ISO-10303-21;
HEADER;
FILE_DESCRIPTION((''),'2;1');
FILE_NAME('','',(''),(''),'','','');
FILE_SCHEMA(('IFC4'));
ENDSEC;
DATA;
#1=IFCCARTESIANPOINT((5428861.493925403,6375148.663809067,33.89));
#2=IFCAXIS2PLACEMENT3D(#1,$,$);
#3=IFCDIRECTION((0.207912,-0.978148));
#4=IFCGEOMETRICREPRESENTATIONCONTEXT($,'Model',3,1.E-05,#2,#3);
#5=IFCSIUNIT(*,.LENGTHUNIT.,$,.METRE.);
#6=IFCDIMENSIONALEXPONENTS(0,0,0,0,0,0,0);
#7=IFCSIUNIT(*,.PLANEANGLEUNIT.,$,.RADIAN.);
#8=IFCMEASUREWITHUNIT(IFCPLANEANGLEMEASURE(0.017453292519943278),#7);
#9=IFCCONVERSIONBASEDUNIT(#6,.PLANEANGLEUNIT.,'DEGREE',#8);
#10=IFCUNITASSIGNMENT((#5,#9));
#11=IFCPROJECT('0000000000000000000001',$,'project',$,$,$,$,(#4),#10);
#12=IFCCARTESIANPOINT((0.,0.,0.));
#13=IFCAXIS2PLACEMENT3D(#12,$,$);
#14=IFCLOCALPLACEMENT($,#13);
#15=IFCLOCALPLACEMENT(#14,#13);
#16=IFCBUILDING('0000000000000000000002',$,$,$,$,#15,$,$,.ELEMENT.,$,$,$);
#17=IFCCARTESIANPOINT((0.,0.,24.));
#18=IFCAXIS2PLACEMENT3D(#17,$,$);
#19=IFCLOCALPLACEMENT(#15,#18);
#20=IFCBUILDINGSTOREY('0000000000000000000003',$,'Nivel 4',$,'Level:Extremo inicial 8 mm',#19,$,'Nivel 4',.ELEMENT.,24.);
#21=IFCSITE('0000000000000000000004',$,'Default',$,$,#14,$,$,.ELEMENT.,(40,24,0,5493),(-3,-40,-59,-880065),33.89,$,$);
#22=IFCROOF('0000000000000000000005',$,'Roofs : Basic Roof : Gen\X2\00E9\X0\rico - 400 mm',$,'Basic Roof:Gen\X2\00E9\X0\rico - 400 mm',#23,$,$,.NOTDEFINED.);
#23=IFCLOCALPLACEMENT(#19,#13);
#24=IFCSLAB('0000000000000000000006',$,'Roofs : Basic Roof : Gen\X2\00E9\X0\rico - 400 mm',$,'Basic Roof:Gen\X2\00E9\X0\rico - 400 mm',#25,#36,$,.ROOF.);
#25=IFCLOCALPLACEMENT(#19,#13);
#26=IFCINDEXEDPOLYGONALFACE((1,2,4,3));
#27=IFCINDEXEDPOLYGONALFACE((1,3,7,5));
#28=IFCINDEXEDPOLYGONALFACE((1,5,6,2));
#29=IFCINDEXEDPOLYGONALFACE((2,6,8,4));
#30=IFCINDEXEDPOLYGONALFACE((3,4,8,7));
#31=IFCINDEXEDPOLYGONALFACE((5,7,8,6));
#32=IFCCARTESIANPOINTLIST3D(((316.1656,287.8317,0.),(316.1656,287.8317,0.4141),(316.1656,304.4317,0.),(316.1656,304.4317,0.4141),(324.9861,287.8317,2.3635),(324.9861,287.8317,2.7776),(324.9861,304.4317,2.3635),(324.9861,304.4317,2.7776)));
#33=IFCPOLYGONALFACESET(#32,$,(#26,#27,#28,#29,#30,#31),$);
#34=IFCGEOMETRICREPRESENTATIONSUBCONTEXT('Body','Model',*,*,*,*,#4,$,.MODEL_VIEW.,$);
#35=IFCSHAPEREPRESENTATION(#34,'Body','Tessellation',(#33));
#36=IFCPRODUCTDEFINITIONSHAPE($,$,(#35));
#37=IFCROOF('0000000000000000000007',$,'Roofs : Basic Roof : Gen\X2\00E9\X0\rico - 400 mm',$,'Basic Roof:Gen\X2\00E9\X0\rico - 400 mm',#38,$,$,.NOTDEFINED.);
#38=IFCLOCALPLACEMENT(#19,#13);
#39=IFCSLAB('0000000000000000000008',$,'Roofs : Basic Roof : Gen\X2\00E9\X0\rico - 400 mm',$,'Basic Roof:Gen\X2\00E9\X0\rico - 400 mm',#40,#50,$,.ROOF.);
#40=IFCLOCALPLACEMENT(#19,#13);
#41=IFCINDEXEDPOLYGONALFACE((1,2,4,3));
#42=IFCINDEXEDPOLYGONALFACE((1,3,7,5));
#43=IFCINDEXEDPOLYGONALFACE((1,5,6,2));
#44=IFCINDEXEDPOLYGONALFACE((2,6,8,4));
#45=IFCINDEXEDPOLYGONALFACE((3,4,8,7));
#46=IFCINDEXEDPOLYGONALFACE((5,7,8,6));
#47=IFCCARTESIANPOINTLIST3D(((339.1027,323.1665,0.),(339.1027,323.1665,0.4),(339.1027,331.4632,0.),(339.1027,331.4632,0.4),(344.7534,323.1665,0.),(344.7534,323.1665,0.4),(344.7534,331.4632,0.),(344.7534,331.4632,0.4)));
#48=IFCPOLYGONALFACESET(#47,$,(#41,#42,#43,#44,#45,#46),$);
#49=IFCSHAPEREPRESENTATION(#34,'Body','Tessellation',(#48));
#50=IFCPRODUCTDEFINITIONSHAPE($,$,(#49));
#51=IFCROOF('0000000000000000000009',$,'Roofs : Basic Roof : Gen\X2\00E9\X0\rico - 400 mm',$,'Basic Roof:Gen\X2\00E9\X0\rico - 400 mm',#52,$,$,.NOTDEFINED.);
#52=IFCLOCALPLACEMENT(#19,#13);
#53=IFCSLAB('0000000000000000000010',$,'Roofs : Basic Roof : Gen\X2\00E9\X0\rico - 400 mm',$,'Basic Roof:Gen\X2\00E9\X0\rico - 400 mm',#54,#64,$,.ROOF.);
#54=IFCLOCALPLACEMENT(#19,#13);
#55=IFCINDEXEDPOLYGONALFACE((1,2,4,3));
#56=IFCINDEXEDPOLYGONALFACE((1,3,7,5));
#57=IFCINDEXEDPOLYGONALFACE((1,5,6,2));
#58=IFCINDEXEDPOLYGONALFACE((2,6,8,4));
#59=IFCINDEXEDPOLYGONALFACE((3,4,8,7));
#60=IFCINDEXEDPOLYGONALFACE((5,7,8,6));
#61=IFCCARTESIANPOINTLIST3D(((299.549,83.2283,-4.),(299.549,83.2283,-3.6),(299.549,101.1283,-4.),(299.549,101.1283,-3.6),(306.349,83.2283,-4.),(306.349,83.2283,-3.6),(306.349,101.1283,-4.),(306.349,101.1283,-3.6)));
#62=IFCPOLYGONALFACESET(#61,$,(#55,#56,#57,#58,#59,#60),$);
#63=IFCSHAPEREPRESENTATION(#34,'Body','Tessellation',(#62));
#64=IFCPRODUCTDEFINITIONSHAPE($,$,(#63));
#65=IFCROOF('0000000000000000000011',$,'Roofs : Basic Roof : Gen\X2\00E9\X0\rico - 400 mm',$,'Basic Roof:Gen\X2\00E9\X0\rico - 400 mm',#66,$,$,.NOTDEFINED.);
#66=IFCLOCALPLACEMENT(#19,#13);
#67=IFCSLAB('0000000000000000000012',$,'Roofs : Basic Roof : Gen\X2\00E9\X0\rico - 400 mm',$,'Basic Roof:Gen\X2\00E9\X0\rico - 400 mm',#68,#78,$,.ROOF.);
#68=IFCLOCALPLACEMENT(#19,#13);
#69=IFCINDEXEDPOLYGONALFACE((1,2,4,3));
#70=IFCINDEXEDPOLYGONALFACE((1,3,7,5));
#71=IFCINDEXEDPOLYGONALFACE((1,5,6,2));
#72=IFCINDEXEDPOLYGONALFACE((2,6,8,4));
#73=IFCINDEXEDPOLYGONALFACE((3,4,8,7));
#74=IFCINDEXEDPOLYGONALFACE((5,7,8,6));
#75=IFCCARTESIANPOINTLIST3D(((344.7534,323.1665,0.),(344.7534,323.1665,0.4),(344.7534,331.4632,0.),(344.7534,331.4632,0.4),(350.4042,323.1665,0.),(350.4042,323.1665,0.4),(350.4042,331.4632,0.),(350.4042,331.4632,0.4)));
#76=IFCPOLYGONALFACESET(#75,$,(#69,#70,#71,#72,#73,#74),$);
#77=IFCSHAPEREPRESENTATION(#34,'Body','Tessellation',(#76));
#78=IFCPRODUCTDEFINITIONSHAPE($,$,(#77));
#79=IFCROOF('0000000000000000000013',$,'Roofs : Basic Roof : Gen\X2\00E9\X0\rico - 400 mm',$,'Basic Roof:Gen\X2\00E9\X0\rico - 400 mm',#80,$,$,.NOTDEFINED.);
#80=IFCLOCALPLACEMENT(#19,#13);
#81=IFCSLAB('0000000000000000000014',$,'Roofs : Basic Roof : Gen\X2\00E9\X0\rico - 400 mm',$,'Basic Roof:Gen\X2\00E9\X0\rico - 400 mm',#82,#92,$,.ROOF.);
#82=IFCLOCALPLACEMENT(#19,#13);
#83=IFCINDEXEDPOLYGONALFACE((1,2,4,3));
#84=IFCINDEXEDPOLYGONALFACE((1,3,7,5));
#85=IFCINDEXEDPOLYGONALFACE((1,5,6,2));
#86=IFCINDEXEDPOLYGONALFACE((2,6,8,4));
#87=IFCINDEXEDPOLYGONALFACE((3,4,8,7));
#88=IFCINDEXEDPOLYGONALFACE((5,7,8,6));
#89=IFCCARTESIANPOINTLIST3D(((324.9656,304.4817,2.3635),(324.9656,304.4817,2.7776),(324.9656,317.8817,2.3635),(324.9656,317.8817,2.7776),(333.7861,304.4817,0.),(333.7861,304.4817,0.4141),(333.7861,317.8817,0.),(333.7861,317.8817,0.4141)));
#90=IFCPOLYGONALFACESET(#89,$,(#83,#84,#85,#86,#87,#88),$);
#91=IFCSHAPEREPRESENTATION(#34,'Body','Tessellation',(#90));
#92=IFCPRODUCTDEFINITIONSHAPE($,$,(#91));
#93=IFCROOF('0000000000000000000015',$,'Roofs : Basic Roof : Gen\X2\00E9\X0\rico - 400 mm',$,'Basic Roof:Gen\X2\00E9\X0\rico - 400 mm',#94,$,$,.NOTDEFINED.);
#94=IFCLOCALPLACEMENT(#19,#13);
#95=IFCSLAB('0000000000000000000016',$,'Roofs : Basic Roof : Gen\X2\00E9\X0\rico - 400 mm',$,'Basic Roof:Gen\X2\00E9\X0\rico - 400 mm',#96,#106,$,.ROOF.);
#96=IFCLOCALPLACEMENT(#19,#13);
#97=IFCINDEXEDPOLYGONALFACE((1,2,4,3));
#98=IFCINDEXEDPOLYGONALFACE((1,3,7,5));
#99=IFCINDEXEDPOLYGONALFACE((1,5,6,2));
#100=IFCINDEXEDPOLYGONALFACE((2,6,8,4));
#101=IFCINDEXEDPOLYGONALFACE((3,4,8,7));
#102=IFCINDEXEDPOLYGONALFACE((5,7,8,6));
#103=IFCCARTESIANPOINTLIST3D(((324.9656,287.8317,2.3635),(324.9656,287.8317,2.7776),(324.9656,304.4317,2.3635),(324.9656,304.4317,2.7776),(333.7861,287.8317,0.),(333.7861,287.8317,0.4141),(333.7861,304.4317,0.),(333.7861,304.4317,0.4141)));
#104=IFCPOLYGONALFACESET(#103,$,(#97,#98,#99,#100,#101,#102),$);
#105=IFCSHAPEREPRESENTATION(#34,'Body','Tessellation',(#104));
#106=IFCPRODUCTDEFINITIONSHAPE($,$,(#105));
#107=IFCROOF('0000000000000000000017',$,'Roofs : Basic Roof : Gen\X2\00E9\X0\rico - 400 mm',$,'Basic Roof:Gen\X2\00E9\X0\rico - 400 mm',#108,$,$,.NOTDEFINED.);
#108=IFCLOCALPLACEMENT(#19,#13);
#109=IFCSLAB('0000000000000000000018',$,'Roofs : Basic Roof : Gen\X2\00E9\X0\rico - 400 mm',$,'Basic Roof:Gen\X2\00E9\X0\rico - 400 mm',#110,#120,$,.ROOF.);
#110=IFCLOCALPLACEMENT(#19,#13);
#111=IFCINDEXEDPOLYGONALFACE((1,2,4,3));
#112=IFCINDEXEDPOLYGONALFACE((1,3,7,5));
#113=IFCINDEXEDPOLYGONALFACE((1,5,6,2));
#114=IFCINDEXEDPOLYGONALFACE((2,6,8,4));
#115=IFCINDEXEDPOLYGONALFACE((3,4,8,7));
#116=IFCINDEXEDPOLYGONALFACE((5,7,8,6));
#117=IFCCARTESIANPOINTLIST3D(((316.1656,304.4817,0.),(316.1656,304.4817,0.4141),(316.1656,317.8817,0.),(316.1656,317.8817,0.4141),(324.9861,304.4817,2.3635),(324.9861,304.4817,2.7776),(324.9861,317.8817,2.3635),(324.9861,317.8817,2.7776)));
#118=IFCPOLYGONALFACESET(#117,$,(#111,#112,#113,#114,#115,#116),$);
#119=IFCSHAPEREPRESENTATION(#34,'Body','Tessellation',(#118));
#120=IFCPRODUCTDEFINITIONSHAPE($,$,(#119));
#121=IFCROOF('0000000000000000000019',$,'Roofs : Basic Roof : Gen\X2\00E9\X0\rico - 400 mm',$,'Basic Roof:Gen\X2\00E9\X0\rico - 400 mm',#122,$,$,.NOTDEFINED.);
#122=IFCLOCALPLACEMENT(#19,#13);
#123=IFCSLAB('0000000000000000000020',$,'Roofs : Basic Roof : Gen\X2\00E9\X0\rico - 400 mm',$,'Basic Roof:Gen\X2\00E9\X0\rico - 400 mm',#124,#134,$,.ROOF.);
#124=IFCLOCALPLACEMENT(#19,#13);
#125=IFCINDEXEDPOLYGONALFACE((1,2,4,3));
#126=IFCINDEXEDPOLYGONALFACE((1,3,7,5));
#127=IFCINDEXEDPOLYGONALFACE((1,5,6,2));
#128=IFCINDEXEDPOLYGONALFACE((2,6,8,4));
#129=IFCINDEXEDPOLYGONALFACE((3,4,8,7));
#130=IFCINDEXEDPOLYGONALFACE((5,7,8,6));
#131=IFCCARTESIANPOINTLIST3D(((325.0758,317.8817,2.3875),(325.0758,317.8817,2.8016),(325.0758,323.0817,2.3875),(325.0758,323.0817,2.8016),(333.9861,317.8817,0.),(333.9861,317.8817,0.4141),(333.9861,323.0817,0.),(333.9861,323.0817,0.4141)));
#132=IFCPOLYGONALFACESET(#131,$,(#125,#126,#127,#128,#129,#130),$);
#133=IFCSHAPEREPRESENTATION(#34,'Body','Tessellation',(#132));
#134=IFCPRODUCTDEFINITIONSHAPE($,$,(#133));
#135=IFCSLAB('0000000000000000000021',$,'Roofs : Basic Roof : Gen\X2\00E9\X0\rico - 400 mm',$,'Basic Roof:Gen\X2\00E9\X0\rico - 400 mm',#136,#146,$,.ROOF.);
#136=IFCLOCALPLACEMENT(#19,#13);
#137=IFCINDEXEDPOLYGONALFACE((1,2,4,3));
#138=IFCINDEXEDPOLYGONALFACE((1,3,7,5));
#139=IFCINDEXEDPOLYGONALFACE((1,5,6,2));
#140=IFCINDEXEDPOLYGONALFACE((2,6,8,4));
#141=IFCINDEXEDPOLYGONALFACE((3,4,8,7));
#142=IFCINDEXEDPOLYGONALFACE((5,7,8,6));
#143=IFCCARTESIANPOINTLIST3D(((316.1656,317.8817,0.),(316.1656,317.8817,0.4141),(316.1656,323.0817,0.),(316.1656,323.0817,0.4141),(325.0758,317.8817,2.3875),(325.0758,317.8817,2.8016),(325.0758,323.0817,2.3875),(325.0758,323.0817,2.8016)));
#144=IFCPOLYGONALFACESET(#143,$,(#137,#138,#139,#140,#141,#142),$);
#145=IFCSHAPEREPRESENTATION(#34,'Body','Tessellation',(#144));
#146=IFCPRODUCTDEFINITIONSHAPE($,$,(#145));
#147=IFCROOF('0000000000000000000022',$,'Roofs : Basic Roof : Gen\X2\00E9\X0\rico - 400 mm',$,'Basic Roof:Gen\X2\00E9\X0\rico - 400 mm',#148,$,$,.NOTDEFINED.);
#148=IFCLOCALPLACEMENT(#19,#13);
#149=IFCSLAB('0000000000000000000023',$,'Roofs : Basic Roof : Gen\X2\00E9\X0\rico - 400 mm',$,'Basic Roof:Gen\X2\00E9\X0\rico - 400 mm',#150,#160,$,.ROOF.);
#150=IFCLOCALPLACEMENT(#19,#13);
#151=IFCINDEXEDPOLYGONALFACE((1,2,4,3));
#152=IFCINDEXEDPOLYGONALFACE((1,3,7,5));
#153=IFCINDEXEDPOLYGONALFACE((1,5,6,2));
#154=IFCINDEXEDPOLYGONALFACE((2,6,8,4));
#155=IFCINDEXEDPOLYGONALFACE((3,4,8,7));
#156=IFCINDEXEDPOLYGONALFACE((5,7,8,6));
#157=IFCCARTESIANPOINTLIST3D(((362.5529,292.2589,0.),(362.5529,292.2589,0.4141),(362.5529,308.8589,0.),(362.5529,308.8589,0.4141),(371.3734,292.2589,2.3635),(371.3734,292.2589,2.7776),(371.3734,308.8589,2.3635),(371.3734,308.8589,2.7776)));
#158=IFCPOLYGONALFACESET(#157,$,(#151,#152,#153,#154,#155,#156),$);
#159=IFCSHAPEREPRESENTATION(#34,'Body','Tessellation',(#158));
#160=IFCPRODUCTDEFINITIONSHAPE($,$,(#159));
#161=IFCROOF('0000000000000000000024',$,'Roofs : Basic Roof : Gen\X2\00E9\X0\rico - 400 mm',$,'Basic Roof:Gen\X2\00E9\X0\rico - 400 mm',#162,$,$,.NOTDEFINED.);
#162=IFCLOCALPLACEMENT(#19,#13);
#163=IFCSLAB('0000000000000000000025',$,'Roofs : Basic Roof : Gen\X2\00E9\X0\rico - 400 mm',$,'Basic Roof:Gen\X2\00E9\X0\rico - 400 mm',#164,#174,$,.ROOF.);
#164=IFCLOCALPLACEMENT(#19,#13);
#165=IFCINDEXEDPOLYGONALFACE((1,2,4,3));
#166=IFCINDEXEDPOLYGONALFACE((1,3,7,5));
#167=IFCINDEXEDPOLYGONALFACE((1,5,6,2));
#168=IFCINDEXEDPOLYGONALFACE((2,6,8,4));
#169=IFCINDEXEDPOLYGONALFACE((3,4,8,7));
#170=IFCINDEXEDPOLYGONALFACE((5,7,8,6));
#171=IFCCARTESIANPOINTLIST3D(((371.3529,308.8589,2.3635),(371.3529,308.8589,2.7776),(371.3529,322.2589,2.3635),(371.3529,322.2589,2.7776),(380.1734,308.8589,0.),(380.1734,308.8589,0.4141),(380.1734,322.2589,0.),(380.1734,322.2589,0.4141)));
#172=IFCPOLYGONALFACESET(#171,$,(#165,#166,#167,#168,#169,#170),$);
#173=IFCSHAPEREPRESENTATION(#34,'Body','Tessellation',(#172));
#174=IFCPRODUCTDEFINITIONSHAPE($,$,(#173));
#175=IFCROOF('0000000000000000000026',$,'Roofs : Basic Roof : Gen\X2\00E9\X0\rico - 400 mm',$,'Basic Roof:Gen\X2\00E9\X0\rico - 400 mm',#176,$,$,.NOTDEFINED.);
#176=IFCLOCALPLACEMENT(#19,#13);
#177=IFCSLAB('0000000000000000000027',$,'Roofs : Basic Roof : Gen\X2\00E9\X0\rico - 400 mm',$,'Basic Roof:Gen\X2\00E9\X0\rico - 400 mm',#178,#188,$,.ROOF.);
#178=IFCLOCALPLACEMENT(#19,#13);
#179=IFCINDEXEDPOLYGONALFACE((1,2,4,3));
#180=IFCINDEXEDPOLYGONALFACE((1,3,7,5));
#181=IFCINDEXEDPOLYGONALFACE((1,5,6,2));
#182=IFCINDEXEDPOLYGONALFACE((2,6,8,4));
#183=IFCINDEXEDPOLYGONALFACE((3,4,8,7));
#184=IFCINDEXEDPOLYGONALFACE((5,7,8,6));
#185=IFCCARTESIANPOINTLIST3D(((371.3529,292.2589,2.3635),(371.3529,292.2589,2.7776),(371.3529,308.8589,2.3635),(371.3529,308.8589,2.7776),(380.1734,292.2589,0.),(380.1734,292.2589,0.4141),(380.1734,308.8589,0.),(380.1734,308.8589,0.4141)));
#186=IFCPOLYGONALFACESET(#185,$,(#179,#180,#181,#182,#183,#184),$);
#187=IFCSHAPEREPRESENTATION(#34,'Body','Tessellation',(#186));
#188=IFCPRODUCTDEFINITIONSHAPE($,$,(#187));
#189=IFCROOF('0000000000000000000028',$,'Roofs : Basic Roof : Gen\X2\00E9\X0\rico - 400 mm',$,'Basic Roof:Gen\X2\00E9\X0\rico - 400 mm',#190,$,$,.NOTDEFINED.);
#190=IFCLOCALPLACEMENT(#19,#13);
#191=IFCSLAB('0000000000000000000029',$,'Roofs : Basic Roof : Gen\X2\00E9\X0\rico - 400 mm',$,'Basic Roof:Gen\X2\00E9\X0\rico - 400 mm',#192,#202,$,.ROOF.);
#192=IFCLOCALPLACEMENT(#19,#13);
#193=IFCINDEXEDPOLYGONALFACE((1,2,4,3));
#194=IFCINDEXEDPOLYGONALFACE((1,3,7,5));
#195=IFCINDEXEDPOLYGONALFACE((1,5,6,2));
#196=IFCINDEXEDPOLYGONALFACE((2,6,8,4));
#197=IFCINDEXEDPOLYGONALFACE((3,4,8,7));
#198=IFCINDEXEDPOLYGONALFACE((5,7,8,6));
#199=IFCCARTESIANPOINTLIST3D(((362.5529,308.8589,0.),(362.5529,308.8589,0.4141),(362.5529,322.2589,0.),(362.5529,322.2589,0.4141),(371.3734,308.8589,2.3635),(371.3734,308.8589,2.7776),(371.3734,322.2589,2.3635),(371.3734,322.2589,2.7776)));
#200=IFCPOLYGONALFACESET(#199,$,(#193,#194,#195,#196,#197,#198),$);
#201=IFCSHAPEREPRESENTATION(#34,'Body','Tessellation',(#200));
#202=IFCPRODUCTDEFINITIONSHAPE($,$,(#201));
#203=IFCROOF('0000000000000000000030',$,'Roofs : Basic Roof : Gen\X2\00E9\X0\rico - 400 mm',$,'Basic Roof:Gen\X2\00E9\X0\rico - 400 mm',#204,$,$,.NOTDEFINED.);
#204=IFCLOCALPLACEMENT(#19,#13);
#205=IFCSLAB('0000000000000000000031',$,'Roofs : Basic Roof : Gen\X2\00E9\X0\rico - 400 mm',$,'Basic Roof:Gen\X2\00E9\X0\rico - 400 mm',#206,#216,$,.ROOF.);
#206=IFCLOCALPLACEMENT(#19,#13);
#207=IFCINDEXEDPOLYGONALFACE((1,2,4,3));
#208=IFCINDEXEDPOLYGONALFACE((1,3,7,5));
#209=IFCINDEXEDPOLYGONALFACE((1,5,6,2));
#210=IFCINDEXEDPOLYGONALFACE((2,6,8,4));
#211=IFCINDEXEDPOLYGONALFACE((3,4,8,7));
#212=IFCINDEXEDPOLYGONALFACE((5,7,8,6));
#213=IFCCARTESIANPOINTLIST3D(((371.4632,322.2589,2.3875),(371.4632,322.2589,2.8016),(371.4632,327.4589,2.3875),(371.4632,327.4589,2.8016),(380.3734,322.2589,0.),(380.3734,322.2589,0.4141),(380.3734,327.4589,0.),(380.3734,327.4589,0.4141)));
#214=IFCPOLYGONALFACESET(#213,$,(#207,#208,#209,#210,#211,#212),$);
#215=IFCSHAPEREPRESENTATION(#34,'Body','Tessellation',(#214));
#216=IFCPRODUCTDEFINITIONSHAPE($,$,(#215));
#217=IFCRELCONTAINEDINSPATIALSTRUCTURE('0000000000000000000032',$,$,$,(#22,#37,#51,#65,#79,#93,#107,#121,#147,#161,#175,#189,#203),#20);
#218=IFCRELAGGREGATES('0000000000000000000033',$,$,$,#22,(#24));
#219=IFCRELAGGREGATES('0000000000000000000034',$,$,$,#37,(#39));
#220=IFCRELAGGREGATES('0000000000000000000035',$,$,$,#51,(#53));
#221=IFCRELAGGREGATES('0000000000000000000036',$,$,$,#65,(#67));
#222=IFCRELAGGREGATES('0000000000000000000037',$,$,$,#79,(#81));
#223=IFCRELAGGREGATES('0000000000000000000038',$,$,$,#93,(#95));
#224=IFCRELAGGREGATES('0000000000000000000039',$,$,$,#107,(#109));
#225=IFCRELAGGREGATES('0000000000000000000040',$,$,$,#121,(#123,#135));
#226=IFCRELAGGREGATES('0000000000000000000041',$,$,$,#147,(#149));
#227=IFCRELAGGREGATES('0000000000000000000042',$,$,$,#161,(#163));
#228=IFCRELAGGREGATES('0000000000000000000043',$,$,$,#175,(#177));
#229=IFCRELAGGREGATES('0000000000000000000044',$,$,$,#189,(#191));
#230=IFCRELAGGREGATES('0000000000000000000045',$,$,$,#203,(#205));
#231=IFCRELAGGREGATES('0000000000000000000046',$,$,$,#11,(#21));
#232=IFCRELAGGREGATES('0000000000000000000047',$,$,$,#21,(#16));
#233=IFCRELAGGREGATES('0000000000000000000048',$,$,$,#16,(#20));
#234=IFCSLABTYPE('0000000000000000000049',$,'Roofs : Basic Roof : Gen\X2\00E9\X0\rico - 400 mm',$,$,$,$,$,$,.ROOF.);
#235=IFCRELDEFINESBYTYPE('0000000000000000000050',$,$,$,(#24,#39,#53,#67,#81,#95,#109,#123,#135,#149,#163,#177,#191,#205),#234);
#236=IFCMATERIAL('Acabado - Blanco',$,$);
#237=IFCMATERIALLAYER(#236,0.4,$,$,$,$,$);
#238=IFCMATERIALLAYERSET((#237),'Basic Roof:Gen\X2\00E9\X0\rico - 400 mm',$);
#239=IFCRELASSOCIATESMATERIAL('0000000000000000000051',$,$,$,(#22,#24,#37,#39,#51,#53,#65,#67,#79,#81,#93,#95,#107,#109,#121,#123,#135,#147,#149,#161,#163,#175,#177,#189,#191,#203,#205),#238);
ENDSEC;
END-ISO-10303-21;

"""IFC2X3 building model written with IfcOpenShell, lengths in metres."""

from ifc_helpers import new_model, entity, si_unit, converted_unit, direction, frame, frame_2d, origin, place, context, subcontext, project, spatial, rectangle, extrude, material, layer, layer_set, type_object, element, aggregate, save


model = new_model("IFC2X3")

# Units and contexts
model_context = context("Model", 3, precision=1e-05, world=frame((5428861.493925403, 6375148.663809067, 33.89)), true_north=direction((0.207912, -0.978148)))
body_context = subcontext(model_context, "Body", "Model", "MODEL_VIEW")
ifc_project = project(units=[si_unit("LENGTHUNIT", "METRE"), converted_unit("PLANEANGLEUNIT", "DEGREE", entity("IfcPlaneAngleMeasure", 0.017453292519943278), si_unit("PLANEANGLEUNIT", "RADIAN"), dimensions=[0, 0, 0, 0, 0, 0, 0])], contexts=[model_context])

# Site, building, storey
site_placement = place(None, origin())
site = spatial("IfcSite", under=ifc_project, at=site_placement, Name="Default", CompositionType="ELEMENT", RefLatitude=(40, 24, 0, 5493), RefLongitude=(-3, -40, -59, -880065), RefElevation=33.89)
building_placement = place(site_placement, origin())
building = spatial("IfcBuilding", under=site, at=building_placement, CompositionType="ELEMENT")
storey_placement = place(building_placement, frame((0.0, 0.0, 24.0)))
storey = spatial("IfcBuildingStorey", under=building, at=storey_placement, Name="Nivel 4", ObjectType="Level:Extremo inicial 8 mm", LongName="Nivel 4", CompositionType="ELEMENT", Elevation=24.0)

# Roofs, slabs
ifc_material = material(Name="Acabado - Blanco")
ifc_layer = layer(ifc_material, 0.4)
ifc_layer_set = layer_set([ifc_layer], Name="Basic Roof:Genérico - 400 mm")
roof_1_placement = place(storey_placement, frame((316.1656, 287.8317, 0.0)))
roof_1 = element("IfcRoof", 1, at=roof_1_placement, inside=storey, material=ifc_layer_set, Name="Roofs : Basic Roof : Genérico - 400 mm", ObjectType="Basic Roof:Genérico - 400 mm", ShapeType="NOTDEFINED")
slab_type = type_object("IfcSlabType", Name="Roofs : Basic Roof : Genérico - 400 mm", PredefinedType="ROOF")
slab_1_placement = place(roof_1_placement, origin())
slab_1 = element("IfcSlab", 2, at=slab_1_placement, type_object=slab_type, material=ifc_layer_set, Name="Roofs : Basic Roof : Genérico - 400 mm", ObjectType="Basic Roof:Genérico - 400 mm", PredefinedType="ROOF", context=body_context, shape_type="SweptSolid", body=[
    extrude(rectangle(XDim=16.6, YDim=9.1317, at=frame_2d((0.0, 0.0), x_axis=(0.0, -1.0))), frame((4.4103, 8.3, 1.1817), z_axis=(-0.258819, 0.0, 0.965926), x_axis=(0.965926, 0.0, 0.258819)), (0.258819, 0.0, 0.965926), 0.4141),
])
aggregate(roof_1, [slab_1])
roof_2_placement = place(storey_placement, frame((339.1027, 323.1665, 0.0)))
roof_2 = element("IfcRoof", 3, at=roof_2_placement, inside=storey, material=ifc_layer_set, Name="Roofs : Basic Roof : Genérico - 400 mm", ObjectType="Basic Roof:Genérico - 400 mm", ShapeType="NOTDEFINED")
slab_2_placement = place(roof_2_placement, origin())
slab_2 = element("IfcSlab", 4, at=slab_2_placement, type_object=slab_type, material=ifc_layer_set, Name="Roofs : Basic Roof : Genérico - 400 mm", ObjectType="Basic Roof:Genérico - 400 mm", PredefinedType="ROOF", context=body_context, shape_type="SweptSolid", body=[
    extrude(rectangle(XDim=8.2967, YDim=5.6508, at=frame_2d((0.0, 0.0), x_axis=(0.0, -1.0))), frame((2.8254, 4.1484, 0.0)), (0.0, 0.0, 1.0), 0.4),
])
aggregate(roof_2, [slab_2])
roof_3_placement = place(storey_placement, frame((299.549, 83.2283, -4.0)))
roof_3 = element("IfcRoof", 5, at=roof_3_placement, inside=storey, material=ifc_layer_set, Name="Roofs : Basic Roof : Genérico - 400 mm", ObjectType="Basic Roof:Genérico - 400 mm", ShapeType="NOTDEFINED")
slab_3_placement = place(roof_3_placement, origin())
slab_3 = element("IfcSlab", 6, at=slab_3_placement, type_object=slab_type, material=ifc_layer_set, Name="Roofs : Basic Roof : Genérico - 400 mm", ObjectType="Basic Roof:Genérico - 400 mm", PredefinedType="ROOF", context=body_context, shape_type="SweptSolid", body=[
    extrude(rectangle(XDim=17.9, YDim=6.8, at=frame_2d((0.0, 0.0), x_axis=(0.0, 1.0))), frame((3.4, 8.95, 0.0)), (0.0, 0.0, 1.0), 0.4),
])
aggregate(roof_3, [slab_3])
roof_4_placement = place(storey_placement, frame((344.7534, 323.1665, 0.0)))
roof_4 = element("IfcRoof", 7, at=roof_4_placement, inside=storey, material=ifc_layer_set, Name="Roofs : Basic Roof : Genérico - 400 mm", ObjectType="Basic Roof:Genérico - 400 mm", ShapeType="NOTDEFINED")
slab_4_placement = place(roof_4_placement, origin())
slab_4 = element("IfcSlab", 8, at=slab_4_placement, type_object=slab_type, material=ifc_layer_set, Name="Roofs : Basic Roof : Genérico - 400 mm", ObjectType="Basic Roof:Genérico - 400 mm", PredefinedType="ROOF", context=body_context, shape_type="SweptSolid", body=[
    extrude(rectangle(XDim=8.2967, YDim=5.6508, at=frame_2d((0.0, 0.0), x_axis=(0.0, -1.0))), frame((2.8254, 4.1484, 0.0)), (0.0, 0.0, 1.0), 0.4),
])
aggregate(roof_4, [slab_4])
roof_5_placement = place(storey_placement, frame((324.9656, 304.4817, 0.0)))
roof_5 = element("IfcRoof", 9, at=roof_5_placement, inside=storey, material=ifc_layer_set, Name="Roofs : Basic Roof : Genérico - 400 mm", ObjectType="Basic Roof:Genérico - 400 mm", ShapeType="NOTDEFINED")
slab_5_placement = place(roof_5_placement, origin())
slab_5 = element("IfcSlab", 10, at=slab_5_placement, type_object=slab_type, material=ifc_layer_set, Name="Roofs : Basic Roof : Genérico - 400 mm", ObjectType="Basic Roof:Genérico - 400 mm", PredefinedType="ROOF", context=body_context, shape_type="SweptSolid", body=[
    extrude(rectangle(XDim=9.1317, YDim=13.4, at=frame_2d((0.0, 0.0), x_axis=(-1.0, 0.0))), frame((4.4103, 6.7, 1.1817), z_axis=(0.258819, 0.0, 0.965926), x_axis=(0.965926, 0.0, -0.258819)), (-0.258819, 0.0, 0.965926), 0.4141),
])
aggregate(roof_5, [slab_5])
roof_6_placement = place(storey_placement, frame((324.9656, 287.8317, 0.0)))
roof_6 = element("IfcRoof", 11, at=roof_6_placement, inside=storey, material=ifc_layer_set, Name="Roofs : Basic Roof : Genérico - 400 mm", ObjectType="Basic Roof:Genérico - 400 mm", ShapeType="NOTDEFINED")
slab_6_placement = place(roof_6_placement, origin())
slab_6 = element("IfcSlab", 12, at=slab_6_placement, type_object=slab_type, material=ifc_layer_set, Name="Roofs : Basic Roof : Genérico - 400 mm", ObjectType="Basic Roof:Genérico - 400 mm", PredefinedType="ROOF", context=body_context, shape_type="SweptSolid", body=[
    extrude(rectangle(XDim=9.1317, YDim=16.6, at=frame_2d((0.0, 0.0), x_axis=(-1.0, 0.0))), frame((4.4103, 8.3, 1.1817), z_axis=(0.258819, 0.0, 0.965926), x_axis=(0.965926, 0.0, -0.258819)), (-0.258819, 0.0, 0.965926), 0.4141),
])
aggregate(roof_6, [slab_6])
roof_7_placement = place(storey_placement, frame((316.1656, 304.4817, 0.0)))
roof_7 = element("IfcRoof", 13, at=roof_7_placement, inside=storey, material=ifc_layer_set, Name="Roofs : Basic Roof : Genérico - 400 mm", ObjectType="Basic Roof:Genérico - 400 mm", ShapeType="NOTDEFINED")
slab_7_placement = place(roof_7_placement, origin())
slab_7 = element("IfcSlab", 14, at=slab_7_placement, type_object=slab_type, material=ifc_layer_set, Name="Roofs : Basic Roof : Genérico - 400 mm", ObjectType="Basic Roof:Genérico - 400 mm", PredefinedType="ROOF", context=body_context, shape_type="SweptSolid", body=[
    extrude(rectangle(XDim=13.4, YDim=9.1317, at=frame_2d((0.0, 0.0), x_axis=(0.0, -1.0))), frame((4.4103, 6.7, 1.1817), z_axis=(-0.258819, 0.0, 0.965926), x_axis=(0.965926, 0.0, 0.258819)), (0.258819, 0.0, 0.965926), 0.4141),
])
aggregate(roof_7, [slab_7])

# Roof, slabs
roof_8_placement = place(storey_placement, frame((316.1656, 317.8817, 0.0)))
roof_8 = element("IfcRoof", 15, at=roof_8_placement, inside=storey, material=ifc_layer_set, Name="Roofs : Basic Roof : Genérico - 400 mm", ObjectType="Basic Roof:Genérico - 400 mm", ShapeType="NOTDEFINED")
slab_8_placement = place(roof_8_placement, origin())
slab_8 = element("IfcSlab", 16, at=slab_8_placement, type_object=slab_type, material=ifc_layer_set, Name="Roofs : Basic Roof : Genérico - 400 mm", ObjectType="Basic Roof:Genérico - 400 mm", PredefinedType="ROOF", context=body_context, shape_type="SweptSolid", body=[
    extrude(rectangle(XDim=5.2, YDim=9.2246, at=frame_2d((0.0, 0.0), x_axis=(0.0, -1.0))), frame((13.3654, 2.6, 1.1937), z_axis=(0.258819, 0.0, 0.965926), x_axis=(0.965926, 0.0, -0.258819)), (-0.258819, 0.0, 0.965926), 0.4141),
])
slab_9_placement = place(roof_8_placement, origin())
slab_9 = element("IfcSlab", 17, at=slab_9_placement, type_object=slab_type, material=ifc_layer_set, Name="Roofs : Basic Roof : Genérico - 400 mm", ObjectType="Basic Roof:Genérico - 400 mm", PredefinedType="ROOF", context=body_context, shape_type="SweptSolid", body=[
    extrude(rectangle(XDim=9.2246, YDim=5.2, at=frame_2d((0.0, 0.0), x_axis=(-1.0, 0.0))), frame((4.4551, 2.6, 1.1937), z_axis=(-0.258819, 0.0, 0.965926), x_axis=(0.965926, 0.0, 0.258819)), (0.258819, 0.0, 0.965926), 0.4141),
])
aggregate(roof_8, [slab_8, slab_9])

# Roofs, slabs
roof_9_placement = place(storey_placement, frame((362.5529, 292.2589, 0.0)))
roof_9 = element("IfcRoof", 18, at=roof_9_placement, inside=storey, material=ifc_layer_set, Name="Roofs : Basic Roof : Genérico - 400 mm", ObjectType="Basic Roof:Genérico - 400 mm", ShapeType="NOTDEFINED")
slab_10_placement = place(roof_9_placement, origin())
slab_10 = element("IfcSlab", 19, at=slab_10_placement, type_object=slab_type, material=ifc_layer_set, Name="Roofs : Basic Roof : Genérico - 400 mm", ObjectType="Basic Roof:Genérico - 400 mm", PredefinedType="ROOF", context=body_context, shape_type="SweptSolid", body=[
    extrude(rectangle(XDim=16.6, YDim=9.1317, at=frame_2d((0.0, 0.0), x_axis=(0.0, -1.0))), frame((4.4103, 8.3, 1.1817), z_axis=(-0.258819, 0.0, 0.965926), x_axis=(0.965926, 0.0, 0.258819)), (0.258819, 0.0, 0.965926), 0.4141),
])
aggregate(roof_9, [slab_10])
roof_10_placement = place(storey_placement, frame((371.3529, 308.8589, 0.0)))
roof_10 = element("IfcRoof", 20, at=roof_10_placement, inside=storey, material=ifc_layer_set, Name="Roofs : Basic Roof : Genérico - 400 mm", ObjectType="Basic Roof:Genérico - 400 mm", ShapeType="NOTDEFINED")
slab_11_placement = place(roof_10_placement, origin())
slab_11 = element("IfcSlab", 21, at=slab_11_placement, type_object=slab_type, material=ifc_layer_set, Name="Roofs : Basic Roof : Genérico - 400 mm", ObjectType="Basic Roof:Genérico - 400 mm", PredefinedType="ROOF", context=body_context, shape_type="SweptSolid", body=[
    extrude(rectangle(XDim=9.1317, YDim=13.4, at=frame_2d((0.0, 0.0), x_axis=(-1.0, 0.0))), frame((4.4103, 6.7, 1.1817), z_axis=(0.258819, 0.0, 0.965926), x_axis=(0.965926, 0.0, -0.258819)), (-0.258819, 0.0, 0.965926), 0.4141),
])
aggregate(roof_10, [slab_11])
roof_11_placement = place(storey_placement, frame((371.3529, 292.2589, 0.0)))
roof_11 = element("IfcRoof", 22, at=roof_11_placement, inside=storey, material=ifc_layer_set, Name="Roofs : Basic Roof : Genérico - 400 mm", ObjectType="Basic Roof:Genérico - 400 mm", ShapeType="NOTDEFINED")
slab_12_placement = place(roof_11_placement, origin())
slab_12 = element("IfcSlab", 23, at=slab_12_placement, type_object=slab_type, material=ifc_layer_set, Name="Roofs : Basic Roof : Genérico - 400 mm", ObjectType="Basic Roof:Genérico - 400 mm", PredefinedType="ROOF", context=body_context, shape_type="SweptSolid", body=[
    extrude(rectangle(XDim=9.1317, YDim=16.6, at=frame_2d((0.0, 0.0), x_axis=(-1.0, 0.0))), frame((4.4103, 8.3, 1.1817), z_axis=(0.258819, 0.0, 0.965926), x_axis=(0.965926, 0.0, -0.258819)), (-0.258819, 0.0, 0.965926), 0.4141),
])
aggregate(roof_11, [slab_12])
roof_12_placement = place(storey_placement, frame((362.5529, 308.8589, 0.0)))
roof_12 = element("IfcRoof", 24, at=roof_12_placement, inside=storey, material=ifc_layer_set, Name="Roofs : Basic Roof : Genérico - 400 mm", ObjectType="Basic Roof:Genérico - 400 mm", ShapeType="NOTDEFINED")
slab_13_placement = place(roof_12_placement, origin())
slab_13 = element("IfcSlab", 25, at=slab_13_placement, type_object=slab_type, material=ifc_layer_set, Name="Roofs : Basic Roof : Genérico - 400 mm", ObjectType="Basic Roof:Genérico - 400 mm", PredefinedType="ROOF", context=body_context, shape_type="SweptSolid", body=[
    extrude(rectangle(XDim=13.4, YDim=9.1317, at=frame_2d((0.0, 0.0), x_axis=(0.0, -1.0))), frame((4.4103, 6.7, 1.1817), z_axis=(-0.258819, 0.0, 0.965926), x_axis=(0.965926, 0.0, 0.258819)), (0.258819, 0.0, 0.965926), 0.4141),
])
aggregate(roof_12, [slab_13])

# Roof, slab
roof_13_placement = place(storey_placement, frame((362.5529, 322.2589, 0.0)))
roof_13 = element("IfcRoof", 26, at=roof_13_placement, inside=storey, material=ifc_layer_set, Name="Roofs : Basic Roof : Genérico - 400 mm", ObjectType="Basic Roof:Genérico - 400 mm", ShapeType="NOTDEFINED")
slab_14_placement = place(roof_13_placement, origin())
slab_14 = element("IfcSlab", 27, at=slab_14_placement, type_object=slab_type, material=ifc_layer_set, Name="Roofs : Basic Roof : Genérico - 400 mm", ObjectType="Basic Roof:Genérico - 400 mm", PredefinedType="ROOF", context=body_context, shape_type="SweptSolid", body=[
    extrude(rectangle(XDim=5.2, YDim=9.2246, at=frame_2d((0.0, 0.0), x_axis=(0.0, -1.0))), frame((13.3654, 2.6, 1.1937), z_axis=(0.258819, 0.0, 0.965926), x_axis=(0.965926, 0.0, -0.258819)), (-0.258819, 0.0, 0.965926), 0.4141),
])
aggregate(roof_13, [slab_14])

save(model, "model.ifc")
